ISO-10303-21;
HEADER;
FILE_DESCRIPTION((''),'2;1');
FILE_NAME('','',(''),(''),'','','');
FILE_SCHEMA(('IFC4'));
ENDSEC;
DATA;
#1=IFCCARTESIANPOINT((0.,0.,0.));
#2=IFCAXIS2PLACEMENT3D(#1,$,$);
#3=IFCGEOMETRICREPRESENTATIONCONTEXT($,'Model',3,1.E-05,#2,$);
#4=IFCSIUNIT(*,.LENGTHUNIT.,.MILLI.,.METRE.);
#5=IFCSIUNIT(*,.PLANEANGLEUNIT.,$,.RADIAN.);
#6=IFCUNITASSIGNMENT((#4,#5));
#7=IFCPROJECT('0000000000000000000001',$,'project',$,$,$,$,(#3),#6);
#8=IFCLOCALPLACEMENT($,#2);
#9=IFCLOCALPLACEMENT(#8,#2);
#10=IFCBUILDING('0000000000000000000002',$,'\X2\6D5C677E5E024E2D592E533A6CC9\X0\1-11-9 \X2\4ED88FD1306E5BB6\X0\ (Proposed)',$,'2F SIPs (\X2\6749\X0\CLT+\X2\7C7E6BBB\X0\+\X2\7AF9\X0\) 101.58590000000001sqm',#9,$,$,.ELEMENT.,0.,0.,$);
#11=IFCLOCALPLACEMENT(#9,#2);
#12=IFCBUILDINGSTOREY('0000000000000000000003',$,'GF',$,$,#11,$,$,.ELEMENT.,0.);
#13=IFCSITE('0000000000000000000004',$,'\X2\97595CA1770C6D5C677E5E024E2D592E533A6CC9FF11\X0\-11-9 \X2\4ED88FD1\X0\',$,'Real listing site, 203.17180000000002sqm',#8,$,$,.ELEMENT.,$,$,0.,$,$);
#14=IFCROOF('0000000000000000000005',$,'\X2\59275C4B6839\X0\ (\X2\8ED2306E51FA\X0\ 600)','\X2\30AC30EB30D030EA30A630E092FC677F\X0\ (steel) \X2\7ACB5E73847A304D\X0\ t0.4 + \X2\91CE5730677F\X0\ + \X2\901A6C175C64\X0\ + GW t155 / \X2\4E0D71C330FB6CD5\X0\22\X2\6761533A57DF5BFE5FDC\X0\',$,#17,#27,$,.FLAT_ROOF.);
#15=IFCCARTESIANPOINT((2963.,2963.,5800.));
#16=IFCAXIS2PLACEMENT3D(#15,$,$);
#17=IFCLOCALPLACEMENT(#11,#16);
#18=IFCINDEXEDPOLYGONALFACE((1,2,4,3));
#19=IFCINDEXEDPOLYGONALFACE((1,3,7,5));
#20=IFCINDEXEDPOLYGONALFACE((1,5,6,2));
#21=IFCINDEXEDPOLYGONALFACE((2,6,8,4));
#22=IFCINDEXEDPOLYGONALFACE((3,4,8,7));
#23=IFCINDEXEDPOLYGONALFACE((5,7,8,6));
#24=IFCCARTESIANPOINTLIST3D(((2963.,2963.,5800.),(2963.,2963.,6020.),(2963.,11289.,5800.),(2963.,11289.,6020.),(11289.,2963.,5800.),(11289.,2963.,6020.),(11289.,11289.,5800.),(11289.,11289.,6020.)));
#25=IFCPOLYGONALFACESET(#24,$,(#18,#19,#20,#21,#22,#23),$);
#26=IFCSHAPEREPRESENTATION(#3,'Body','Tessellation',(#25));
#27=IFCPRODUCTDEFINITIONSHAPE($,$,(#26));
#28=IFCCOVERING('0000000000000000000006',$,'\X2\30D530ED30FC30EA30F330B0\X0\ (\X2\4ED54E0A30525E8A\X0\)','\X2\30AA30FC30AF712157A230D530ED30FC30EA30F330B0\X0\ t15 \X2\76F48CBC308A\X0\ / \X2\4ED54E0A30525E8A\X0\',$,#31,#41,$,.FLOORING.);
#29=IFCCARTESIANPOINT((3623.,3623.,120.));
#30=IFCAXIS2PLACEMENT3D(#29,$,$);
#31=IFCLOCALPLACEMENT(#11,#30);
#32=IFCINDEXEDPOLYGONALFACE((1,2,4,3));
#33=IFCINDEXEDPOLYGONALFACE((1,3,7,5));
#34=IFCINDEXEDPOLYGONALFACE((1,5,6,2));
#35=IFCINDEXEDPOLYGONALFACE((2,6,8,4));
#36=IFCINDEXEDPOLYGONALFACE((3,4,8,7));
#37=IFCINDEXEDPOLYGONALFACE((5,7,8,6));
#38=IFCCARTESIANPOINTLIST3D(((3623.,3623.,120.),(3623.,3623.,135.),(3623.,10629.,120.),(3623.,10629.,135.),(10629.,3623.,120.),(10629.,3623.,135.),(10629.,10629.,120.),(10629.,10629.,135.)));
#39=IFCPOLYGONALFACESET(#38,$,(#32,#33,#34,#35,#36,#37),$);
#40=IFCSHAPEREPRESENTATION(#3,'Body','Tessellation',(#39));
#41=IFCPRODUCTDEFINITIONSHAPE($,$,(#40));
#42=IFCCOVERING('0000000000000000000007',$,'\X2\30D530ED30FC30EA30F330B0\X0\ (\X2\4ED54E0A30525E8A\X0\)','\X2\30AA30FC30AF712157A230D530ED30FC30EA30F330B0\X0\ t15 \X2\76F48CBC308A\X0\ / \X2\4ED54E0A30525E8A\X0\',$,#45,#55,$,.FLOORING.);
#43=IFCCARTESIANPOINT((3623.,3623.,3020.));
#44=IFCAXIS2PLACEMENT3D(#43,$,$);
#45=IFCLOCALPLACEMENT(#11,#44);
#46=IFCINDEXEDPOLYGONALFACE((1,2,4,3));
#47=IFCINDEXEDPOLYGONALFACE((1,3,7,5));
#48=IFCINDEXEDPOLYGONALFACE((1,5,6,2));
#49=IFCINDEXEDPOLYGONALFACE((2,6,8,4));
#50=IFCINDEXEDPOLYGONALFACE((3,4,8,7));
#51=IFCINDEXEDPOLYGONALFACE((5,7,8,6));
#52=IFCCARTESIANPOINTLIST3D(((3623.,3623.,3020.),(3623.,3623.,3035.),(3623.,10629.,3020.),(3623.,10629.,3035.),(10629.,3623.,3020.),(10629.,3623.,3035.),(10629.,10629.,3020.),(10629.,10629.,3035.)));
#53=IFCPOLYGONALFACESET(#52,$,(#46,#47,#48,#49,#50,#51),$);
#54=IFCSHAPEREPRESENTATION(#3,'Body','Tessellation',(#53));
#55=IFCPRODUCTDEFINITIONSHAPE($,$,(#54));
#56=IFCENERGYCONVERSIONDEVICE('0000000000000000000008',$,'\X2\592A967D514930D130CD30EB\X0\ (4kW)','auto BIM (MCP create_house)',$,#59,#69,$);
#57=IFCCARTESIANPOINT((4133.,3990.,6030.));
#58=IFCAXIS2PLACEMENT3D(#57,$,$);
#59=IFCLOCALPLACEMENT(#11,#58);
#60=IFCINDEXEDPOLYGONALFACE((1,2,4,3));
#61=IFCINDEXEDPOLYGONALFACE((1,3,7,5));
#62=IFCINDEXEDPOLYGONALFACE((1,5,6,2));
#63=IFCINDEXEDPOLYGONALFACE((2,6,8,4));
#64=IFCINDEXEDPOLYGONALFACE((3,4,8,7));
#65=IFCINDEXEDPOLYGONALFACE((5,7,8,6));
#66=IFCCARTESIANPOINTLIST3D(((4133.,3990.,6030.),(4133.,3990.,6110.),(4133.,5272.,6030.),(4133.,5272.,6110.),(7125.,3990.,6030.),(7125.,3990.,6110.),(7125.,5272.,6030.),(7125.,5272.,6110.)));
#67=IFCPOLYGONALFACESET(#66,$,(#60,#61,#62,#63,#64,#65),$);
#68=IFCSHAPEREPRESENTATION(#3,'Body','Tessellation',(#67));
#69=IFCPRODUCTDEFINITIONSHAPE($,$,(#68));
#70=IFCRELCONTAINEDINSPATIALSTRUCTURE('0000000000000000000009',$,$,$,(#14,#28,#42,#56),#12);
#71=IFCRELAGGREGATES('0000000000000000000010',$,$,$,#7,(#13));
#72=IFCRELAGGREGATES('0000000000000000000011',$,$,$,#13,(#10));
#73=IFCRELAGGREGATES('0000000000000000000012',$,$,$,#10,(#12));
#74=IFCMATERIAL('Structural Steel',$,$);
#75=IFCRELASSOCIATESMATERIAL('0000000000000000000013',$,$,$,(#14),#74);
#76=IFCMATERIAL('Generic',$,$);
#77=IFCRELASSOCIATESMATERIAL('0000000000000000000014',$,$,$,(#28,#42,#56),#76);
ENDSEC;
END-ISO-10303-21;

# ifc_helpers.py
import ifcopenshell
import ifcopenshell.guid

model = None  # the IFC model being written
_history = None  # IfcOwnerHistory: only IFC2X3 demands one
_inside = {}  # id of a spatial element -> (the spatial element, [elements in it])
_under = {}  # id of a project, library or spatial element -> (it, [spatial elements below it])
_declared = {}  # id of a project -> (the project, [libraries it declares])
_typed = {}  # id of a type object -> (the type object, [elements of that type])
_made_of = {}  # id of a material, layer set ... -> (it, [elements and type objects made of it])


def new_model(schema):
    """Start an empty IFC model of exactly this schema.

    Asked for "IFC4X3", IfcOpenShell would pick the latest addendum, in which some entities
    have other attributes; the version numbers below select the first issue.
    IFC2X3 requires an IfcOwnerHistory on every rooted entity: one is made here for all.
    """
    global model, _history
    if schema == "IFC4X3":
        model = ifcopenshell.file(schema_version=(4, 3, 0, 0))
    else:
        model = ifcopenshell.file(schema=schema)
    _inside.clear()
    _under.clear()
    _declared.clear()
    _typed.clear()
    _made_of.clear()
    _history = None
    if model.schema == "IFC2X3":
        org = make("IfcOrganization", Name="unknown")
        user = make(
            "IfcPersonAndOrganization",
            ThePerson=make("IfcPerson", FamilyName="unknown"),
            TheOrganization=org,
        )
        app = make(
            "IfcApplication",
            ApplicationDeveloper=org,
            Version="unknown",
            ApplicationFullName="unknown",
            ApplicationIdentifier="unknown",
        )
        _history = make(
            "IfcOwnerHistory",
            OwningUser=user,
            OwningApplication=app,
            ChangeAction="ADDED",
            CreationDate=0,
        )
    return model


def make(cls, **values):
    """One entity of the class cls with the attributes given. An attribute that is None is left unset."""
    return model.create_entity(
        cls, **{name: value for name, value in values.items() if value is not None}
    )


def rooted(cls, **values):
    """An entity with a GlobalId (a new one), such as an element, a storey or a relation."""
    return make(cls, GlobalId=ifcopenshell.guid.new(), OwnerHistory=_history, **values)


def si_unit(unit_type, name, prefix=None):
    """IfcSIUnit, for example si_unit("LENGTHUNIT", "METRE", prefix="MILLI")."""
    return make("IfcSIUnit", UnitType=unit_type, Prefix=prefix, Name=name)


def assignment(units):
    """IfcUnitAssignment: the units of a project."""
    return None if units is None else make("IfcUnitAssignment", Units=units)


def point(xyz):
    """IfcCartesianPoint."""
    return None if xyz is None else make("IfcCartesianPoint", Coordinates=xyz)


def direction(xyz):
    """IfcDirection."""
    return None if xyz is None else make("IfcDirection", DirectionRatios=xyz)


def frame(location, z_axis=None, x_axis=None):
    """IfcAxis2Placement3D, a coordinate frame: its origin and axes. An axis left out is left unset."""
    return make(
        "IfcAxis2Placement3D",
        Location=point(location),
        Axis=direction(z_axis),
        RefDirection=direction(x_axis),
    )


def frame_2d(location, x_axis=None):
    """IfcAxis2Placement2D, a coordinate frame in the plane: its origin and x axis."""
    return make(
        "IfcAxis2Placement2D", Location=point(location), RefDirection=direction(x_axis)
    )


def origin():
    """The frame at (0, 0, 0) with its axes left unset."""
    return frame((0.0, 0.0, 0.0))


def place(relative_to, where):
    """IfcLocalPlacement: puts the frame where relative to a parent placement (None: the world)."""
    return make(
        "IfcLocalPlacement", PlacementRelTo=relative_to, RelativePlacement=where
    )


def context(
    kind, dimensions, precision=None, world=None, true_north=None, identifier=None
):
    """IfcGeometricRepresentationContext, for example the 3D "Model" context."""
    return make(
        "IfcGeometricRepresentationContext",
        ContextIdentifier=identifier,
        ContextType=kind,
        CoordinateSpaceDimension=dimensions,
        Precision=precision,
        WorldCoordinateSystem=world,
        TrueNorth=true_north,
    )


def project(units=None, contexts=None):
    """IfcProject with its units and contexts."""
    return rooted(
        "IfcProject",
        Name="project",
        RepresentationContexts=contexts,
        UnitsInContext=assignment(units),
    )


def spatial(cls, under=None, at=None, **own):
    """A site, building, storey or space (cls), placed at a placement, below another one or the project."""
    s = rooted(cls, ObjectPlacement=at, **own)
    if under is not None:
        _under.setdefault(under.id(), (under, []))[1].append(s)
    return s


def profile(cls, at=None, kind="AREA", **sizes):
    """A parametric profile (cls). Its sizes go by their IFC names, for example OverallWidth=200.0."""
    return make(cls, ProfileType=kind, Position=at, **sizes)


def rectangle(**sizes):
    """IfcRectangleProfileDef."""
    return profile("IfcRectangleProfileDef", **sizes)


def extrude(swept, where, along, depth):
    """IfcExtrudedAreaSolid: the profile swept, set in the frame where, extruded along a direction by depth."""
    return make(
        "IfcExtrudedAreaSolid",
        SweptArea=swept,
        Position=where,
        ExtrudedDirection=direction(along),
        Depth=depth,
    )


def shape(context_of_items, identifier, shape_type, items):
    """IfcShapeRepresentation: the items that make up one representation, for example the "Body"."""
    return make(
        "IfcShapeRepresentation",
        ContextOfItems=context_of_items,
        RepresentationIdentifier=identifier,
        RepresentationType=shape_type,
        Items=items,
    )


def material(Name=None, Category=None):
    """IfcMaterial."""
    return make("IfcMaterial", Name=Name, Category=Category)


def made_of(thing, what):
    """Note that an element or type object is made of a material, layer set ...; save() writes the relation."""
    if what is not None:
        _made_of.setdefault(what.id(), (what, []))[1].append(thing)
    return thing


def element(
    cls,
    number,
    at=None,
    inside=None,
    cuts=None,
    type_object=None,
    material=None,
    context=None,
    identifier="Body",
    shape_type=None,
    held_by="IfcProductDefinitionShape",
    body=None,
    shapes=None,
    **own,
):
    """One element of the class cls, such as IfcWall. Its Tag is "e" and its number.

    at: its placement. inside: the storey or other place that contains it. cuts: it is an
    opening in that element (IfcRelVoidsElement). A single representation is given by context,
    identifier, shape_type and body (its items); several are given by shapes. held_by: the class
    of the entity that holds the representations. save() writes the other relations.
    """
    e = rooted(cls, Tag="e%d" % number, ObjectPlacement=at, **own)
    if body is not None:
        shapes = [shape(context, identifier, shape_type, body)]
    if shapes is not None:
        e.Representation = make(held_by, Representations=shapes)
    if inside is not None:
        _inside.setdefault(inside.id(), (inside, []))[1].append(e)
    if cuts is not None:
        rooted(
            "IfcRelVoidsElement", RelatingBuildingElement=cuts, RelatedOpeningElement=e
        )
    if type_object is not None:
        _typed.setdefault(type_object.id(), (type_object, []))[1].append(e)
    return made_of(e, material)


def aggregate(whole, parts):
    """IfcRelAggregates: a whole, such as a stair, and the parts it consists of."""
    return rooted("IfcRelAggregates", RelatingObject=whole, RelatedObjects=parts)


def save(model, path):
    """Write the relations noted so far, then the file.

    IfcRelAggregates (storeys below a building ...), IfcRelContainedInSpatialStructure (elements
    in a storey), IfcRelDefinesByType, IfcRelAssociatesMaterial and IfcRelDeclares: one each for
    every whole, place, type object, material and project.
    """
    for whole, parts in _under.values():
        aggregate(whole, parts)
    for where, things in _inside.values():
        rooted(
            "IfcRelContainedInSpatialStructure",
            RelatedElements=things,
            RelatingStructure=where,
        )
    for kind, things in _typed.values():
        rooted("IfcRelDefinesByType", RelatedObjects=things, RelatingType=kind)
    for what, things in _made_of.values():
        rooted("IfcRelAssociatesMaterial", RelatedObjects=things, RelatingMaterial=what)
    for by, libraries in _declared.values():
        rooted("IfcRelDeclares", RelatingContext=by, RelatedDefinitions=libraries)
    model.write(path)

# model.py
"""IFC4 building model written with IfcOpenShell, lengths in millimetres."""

from ifc_helpers import new_model, si_unit, frame, frame_2d, origin, place, context, project, spatial, rectangle, extrude, material, element, save


model = new_model("IFC4")

# Units and contexts
model_context = context("Model", 3, precision=1e-05, world=origin())
ifc_project = project(units=[si_unit("LENGTHUNIT", "METRE", prefix="MILLI"), si_unit("PLANEANGLEUNIT", "RADIAN")], contexts=[model_context])

# Site, building, storey
site_placement = place(None, origin())
site = spatial("IfcSite", under=ifc_project, at=site_placement, Name="静岡県浜松市中央区泉１-11-9 付近", ObjectType="Real listing site, 203.17180000000002sqm", CompositionType="ELEMENT", RefElevation=0.0)
building_placement = place(site_placement, origin())
building = spatial("IfcBuilding", under=site, at=building_placement, Name="浜松市中央区泉1-11-9 付近の家 (Proposed)", ObjectType="2F SIPs (杉CLT+籾殻+竹) 101.58590000000001sqm", CompositionType="ELEMENT", ElevationOfRefHeight=0.0, ElevationOfTerrain=0.0)
storey_placement = place(building_placement, origin())
storey = spatial("IfcBuildingStorey", under=building, at=storey_placement, Name="GF", CompositionType="ELEMENT", Elevation=0.0)

# Roof
ifc_material_1 = material(Name="Structural Steel")
roof_placement = place(storey_placement, frame((2963.0, 2963.0, 5800.0)))
element("IfcRoof", 1, at=roof_placement, inside=storey, material=ifc_material_1, Name="大屋根 (軒の出 600)", Description="ガルバリウム鋼板 (steel) 立平葺き t0.4 + 野地板 + 通気層 + GW t155 / 不燃・法22条区域対応", PredefinedType="FLAT_ROOF", context=model_context, shape_type="SweptSolid", body=[
    extrude(rectangle(XDim=8326.0, YDim=8326.0, at=frame_2d((4163.0, 4163.0))), frame((2963.0, 2963.0, 5800.0)), (0.0, 0.0, 1.0), 220.0),
])

# Coverings
ifc_material_2 = material(Name="Generic")
covering_1_placement = place(storey_placement, frame((3623.0, 3623.0, 120.0)))
element("IfcCovering", 2, at=covering_1_placement, inside=storey, material=ifc_material_2, Name="フローリング (仕上げ床)", Description="オーク無垢フローリング t15 直貼り / 仕上げ床", PredefinedType="FLOORING", context=model_context, shape_type="SweptSolid", body=[
    extrude(rectangle(XDim=7006.0, YDim=7006.0, at=frame_2d((3503.0, 3503.0))), frame((3623.0, 3623.0, 120.0)), (0.0, 0.0, 1.0), 15.0),
])
covering_2_placement = place(storey_placement, frame((3623.0, 3623.0, 3020.0)))
element("IfcCovering", 3, at=covering_2_placement, inside=storey, material=ifc_material_2, Name="フローリング (仕上げ床)", Description="オーク無垢フローリング t15 直貼り / 仕上げ床", PredefinedType="FLOORING", context=model_context, shape_type="SweptSolid", body=[
    extrude(rectangle(XDim=7006.0, YDim=7006.0, at=frame_2d((3503.0, 3503.0))), frame((3623.0, 3623.0, 3020.0)), (0.0, 0.0, 1.0), 15.0),
])

# Energy conversion device
energy_conversion_device_placement = place(storey_placement, frame((4133.0, 3990.0, 6030.0)))
element("IfcEnergyConversionDevice", 4, at=energy_conversion_device_placement, inside=storey, material=ifc_material_2, Name="太陽光パネル (4kW)", Description="auto BIM (MCP create_house)", context=model_context, shape_type="SweptSolid", body=[
    extrude(rectangle(XDim=2992.0, YDim=1282.0, at=frame_2d((1496.0, 641.0))), frame((4133.0, 3990.0, 6030.0)), (0.0, 0.0, 1.0), 80.0),
])

save(model, "model.ifc")
